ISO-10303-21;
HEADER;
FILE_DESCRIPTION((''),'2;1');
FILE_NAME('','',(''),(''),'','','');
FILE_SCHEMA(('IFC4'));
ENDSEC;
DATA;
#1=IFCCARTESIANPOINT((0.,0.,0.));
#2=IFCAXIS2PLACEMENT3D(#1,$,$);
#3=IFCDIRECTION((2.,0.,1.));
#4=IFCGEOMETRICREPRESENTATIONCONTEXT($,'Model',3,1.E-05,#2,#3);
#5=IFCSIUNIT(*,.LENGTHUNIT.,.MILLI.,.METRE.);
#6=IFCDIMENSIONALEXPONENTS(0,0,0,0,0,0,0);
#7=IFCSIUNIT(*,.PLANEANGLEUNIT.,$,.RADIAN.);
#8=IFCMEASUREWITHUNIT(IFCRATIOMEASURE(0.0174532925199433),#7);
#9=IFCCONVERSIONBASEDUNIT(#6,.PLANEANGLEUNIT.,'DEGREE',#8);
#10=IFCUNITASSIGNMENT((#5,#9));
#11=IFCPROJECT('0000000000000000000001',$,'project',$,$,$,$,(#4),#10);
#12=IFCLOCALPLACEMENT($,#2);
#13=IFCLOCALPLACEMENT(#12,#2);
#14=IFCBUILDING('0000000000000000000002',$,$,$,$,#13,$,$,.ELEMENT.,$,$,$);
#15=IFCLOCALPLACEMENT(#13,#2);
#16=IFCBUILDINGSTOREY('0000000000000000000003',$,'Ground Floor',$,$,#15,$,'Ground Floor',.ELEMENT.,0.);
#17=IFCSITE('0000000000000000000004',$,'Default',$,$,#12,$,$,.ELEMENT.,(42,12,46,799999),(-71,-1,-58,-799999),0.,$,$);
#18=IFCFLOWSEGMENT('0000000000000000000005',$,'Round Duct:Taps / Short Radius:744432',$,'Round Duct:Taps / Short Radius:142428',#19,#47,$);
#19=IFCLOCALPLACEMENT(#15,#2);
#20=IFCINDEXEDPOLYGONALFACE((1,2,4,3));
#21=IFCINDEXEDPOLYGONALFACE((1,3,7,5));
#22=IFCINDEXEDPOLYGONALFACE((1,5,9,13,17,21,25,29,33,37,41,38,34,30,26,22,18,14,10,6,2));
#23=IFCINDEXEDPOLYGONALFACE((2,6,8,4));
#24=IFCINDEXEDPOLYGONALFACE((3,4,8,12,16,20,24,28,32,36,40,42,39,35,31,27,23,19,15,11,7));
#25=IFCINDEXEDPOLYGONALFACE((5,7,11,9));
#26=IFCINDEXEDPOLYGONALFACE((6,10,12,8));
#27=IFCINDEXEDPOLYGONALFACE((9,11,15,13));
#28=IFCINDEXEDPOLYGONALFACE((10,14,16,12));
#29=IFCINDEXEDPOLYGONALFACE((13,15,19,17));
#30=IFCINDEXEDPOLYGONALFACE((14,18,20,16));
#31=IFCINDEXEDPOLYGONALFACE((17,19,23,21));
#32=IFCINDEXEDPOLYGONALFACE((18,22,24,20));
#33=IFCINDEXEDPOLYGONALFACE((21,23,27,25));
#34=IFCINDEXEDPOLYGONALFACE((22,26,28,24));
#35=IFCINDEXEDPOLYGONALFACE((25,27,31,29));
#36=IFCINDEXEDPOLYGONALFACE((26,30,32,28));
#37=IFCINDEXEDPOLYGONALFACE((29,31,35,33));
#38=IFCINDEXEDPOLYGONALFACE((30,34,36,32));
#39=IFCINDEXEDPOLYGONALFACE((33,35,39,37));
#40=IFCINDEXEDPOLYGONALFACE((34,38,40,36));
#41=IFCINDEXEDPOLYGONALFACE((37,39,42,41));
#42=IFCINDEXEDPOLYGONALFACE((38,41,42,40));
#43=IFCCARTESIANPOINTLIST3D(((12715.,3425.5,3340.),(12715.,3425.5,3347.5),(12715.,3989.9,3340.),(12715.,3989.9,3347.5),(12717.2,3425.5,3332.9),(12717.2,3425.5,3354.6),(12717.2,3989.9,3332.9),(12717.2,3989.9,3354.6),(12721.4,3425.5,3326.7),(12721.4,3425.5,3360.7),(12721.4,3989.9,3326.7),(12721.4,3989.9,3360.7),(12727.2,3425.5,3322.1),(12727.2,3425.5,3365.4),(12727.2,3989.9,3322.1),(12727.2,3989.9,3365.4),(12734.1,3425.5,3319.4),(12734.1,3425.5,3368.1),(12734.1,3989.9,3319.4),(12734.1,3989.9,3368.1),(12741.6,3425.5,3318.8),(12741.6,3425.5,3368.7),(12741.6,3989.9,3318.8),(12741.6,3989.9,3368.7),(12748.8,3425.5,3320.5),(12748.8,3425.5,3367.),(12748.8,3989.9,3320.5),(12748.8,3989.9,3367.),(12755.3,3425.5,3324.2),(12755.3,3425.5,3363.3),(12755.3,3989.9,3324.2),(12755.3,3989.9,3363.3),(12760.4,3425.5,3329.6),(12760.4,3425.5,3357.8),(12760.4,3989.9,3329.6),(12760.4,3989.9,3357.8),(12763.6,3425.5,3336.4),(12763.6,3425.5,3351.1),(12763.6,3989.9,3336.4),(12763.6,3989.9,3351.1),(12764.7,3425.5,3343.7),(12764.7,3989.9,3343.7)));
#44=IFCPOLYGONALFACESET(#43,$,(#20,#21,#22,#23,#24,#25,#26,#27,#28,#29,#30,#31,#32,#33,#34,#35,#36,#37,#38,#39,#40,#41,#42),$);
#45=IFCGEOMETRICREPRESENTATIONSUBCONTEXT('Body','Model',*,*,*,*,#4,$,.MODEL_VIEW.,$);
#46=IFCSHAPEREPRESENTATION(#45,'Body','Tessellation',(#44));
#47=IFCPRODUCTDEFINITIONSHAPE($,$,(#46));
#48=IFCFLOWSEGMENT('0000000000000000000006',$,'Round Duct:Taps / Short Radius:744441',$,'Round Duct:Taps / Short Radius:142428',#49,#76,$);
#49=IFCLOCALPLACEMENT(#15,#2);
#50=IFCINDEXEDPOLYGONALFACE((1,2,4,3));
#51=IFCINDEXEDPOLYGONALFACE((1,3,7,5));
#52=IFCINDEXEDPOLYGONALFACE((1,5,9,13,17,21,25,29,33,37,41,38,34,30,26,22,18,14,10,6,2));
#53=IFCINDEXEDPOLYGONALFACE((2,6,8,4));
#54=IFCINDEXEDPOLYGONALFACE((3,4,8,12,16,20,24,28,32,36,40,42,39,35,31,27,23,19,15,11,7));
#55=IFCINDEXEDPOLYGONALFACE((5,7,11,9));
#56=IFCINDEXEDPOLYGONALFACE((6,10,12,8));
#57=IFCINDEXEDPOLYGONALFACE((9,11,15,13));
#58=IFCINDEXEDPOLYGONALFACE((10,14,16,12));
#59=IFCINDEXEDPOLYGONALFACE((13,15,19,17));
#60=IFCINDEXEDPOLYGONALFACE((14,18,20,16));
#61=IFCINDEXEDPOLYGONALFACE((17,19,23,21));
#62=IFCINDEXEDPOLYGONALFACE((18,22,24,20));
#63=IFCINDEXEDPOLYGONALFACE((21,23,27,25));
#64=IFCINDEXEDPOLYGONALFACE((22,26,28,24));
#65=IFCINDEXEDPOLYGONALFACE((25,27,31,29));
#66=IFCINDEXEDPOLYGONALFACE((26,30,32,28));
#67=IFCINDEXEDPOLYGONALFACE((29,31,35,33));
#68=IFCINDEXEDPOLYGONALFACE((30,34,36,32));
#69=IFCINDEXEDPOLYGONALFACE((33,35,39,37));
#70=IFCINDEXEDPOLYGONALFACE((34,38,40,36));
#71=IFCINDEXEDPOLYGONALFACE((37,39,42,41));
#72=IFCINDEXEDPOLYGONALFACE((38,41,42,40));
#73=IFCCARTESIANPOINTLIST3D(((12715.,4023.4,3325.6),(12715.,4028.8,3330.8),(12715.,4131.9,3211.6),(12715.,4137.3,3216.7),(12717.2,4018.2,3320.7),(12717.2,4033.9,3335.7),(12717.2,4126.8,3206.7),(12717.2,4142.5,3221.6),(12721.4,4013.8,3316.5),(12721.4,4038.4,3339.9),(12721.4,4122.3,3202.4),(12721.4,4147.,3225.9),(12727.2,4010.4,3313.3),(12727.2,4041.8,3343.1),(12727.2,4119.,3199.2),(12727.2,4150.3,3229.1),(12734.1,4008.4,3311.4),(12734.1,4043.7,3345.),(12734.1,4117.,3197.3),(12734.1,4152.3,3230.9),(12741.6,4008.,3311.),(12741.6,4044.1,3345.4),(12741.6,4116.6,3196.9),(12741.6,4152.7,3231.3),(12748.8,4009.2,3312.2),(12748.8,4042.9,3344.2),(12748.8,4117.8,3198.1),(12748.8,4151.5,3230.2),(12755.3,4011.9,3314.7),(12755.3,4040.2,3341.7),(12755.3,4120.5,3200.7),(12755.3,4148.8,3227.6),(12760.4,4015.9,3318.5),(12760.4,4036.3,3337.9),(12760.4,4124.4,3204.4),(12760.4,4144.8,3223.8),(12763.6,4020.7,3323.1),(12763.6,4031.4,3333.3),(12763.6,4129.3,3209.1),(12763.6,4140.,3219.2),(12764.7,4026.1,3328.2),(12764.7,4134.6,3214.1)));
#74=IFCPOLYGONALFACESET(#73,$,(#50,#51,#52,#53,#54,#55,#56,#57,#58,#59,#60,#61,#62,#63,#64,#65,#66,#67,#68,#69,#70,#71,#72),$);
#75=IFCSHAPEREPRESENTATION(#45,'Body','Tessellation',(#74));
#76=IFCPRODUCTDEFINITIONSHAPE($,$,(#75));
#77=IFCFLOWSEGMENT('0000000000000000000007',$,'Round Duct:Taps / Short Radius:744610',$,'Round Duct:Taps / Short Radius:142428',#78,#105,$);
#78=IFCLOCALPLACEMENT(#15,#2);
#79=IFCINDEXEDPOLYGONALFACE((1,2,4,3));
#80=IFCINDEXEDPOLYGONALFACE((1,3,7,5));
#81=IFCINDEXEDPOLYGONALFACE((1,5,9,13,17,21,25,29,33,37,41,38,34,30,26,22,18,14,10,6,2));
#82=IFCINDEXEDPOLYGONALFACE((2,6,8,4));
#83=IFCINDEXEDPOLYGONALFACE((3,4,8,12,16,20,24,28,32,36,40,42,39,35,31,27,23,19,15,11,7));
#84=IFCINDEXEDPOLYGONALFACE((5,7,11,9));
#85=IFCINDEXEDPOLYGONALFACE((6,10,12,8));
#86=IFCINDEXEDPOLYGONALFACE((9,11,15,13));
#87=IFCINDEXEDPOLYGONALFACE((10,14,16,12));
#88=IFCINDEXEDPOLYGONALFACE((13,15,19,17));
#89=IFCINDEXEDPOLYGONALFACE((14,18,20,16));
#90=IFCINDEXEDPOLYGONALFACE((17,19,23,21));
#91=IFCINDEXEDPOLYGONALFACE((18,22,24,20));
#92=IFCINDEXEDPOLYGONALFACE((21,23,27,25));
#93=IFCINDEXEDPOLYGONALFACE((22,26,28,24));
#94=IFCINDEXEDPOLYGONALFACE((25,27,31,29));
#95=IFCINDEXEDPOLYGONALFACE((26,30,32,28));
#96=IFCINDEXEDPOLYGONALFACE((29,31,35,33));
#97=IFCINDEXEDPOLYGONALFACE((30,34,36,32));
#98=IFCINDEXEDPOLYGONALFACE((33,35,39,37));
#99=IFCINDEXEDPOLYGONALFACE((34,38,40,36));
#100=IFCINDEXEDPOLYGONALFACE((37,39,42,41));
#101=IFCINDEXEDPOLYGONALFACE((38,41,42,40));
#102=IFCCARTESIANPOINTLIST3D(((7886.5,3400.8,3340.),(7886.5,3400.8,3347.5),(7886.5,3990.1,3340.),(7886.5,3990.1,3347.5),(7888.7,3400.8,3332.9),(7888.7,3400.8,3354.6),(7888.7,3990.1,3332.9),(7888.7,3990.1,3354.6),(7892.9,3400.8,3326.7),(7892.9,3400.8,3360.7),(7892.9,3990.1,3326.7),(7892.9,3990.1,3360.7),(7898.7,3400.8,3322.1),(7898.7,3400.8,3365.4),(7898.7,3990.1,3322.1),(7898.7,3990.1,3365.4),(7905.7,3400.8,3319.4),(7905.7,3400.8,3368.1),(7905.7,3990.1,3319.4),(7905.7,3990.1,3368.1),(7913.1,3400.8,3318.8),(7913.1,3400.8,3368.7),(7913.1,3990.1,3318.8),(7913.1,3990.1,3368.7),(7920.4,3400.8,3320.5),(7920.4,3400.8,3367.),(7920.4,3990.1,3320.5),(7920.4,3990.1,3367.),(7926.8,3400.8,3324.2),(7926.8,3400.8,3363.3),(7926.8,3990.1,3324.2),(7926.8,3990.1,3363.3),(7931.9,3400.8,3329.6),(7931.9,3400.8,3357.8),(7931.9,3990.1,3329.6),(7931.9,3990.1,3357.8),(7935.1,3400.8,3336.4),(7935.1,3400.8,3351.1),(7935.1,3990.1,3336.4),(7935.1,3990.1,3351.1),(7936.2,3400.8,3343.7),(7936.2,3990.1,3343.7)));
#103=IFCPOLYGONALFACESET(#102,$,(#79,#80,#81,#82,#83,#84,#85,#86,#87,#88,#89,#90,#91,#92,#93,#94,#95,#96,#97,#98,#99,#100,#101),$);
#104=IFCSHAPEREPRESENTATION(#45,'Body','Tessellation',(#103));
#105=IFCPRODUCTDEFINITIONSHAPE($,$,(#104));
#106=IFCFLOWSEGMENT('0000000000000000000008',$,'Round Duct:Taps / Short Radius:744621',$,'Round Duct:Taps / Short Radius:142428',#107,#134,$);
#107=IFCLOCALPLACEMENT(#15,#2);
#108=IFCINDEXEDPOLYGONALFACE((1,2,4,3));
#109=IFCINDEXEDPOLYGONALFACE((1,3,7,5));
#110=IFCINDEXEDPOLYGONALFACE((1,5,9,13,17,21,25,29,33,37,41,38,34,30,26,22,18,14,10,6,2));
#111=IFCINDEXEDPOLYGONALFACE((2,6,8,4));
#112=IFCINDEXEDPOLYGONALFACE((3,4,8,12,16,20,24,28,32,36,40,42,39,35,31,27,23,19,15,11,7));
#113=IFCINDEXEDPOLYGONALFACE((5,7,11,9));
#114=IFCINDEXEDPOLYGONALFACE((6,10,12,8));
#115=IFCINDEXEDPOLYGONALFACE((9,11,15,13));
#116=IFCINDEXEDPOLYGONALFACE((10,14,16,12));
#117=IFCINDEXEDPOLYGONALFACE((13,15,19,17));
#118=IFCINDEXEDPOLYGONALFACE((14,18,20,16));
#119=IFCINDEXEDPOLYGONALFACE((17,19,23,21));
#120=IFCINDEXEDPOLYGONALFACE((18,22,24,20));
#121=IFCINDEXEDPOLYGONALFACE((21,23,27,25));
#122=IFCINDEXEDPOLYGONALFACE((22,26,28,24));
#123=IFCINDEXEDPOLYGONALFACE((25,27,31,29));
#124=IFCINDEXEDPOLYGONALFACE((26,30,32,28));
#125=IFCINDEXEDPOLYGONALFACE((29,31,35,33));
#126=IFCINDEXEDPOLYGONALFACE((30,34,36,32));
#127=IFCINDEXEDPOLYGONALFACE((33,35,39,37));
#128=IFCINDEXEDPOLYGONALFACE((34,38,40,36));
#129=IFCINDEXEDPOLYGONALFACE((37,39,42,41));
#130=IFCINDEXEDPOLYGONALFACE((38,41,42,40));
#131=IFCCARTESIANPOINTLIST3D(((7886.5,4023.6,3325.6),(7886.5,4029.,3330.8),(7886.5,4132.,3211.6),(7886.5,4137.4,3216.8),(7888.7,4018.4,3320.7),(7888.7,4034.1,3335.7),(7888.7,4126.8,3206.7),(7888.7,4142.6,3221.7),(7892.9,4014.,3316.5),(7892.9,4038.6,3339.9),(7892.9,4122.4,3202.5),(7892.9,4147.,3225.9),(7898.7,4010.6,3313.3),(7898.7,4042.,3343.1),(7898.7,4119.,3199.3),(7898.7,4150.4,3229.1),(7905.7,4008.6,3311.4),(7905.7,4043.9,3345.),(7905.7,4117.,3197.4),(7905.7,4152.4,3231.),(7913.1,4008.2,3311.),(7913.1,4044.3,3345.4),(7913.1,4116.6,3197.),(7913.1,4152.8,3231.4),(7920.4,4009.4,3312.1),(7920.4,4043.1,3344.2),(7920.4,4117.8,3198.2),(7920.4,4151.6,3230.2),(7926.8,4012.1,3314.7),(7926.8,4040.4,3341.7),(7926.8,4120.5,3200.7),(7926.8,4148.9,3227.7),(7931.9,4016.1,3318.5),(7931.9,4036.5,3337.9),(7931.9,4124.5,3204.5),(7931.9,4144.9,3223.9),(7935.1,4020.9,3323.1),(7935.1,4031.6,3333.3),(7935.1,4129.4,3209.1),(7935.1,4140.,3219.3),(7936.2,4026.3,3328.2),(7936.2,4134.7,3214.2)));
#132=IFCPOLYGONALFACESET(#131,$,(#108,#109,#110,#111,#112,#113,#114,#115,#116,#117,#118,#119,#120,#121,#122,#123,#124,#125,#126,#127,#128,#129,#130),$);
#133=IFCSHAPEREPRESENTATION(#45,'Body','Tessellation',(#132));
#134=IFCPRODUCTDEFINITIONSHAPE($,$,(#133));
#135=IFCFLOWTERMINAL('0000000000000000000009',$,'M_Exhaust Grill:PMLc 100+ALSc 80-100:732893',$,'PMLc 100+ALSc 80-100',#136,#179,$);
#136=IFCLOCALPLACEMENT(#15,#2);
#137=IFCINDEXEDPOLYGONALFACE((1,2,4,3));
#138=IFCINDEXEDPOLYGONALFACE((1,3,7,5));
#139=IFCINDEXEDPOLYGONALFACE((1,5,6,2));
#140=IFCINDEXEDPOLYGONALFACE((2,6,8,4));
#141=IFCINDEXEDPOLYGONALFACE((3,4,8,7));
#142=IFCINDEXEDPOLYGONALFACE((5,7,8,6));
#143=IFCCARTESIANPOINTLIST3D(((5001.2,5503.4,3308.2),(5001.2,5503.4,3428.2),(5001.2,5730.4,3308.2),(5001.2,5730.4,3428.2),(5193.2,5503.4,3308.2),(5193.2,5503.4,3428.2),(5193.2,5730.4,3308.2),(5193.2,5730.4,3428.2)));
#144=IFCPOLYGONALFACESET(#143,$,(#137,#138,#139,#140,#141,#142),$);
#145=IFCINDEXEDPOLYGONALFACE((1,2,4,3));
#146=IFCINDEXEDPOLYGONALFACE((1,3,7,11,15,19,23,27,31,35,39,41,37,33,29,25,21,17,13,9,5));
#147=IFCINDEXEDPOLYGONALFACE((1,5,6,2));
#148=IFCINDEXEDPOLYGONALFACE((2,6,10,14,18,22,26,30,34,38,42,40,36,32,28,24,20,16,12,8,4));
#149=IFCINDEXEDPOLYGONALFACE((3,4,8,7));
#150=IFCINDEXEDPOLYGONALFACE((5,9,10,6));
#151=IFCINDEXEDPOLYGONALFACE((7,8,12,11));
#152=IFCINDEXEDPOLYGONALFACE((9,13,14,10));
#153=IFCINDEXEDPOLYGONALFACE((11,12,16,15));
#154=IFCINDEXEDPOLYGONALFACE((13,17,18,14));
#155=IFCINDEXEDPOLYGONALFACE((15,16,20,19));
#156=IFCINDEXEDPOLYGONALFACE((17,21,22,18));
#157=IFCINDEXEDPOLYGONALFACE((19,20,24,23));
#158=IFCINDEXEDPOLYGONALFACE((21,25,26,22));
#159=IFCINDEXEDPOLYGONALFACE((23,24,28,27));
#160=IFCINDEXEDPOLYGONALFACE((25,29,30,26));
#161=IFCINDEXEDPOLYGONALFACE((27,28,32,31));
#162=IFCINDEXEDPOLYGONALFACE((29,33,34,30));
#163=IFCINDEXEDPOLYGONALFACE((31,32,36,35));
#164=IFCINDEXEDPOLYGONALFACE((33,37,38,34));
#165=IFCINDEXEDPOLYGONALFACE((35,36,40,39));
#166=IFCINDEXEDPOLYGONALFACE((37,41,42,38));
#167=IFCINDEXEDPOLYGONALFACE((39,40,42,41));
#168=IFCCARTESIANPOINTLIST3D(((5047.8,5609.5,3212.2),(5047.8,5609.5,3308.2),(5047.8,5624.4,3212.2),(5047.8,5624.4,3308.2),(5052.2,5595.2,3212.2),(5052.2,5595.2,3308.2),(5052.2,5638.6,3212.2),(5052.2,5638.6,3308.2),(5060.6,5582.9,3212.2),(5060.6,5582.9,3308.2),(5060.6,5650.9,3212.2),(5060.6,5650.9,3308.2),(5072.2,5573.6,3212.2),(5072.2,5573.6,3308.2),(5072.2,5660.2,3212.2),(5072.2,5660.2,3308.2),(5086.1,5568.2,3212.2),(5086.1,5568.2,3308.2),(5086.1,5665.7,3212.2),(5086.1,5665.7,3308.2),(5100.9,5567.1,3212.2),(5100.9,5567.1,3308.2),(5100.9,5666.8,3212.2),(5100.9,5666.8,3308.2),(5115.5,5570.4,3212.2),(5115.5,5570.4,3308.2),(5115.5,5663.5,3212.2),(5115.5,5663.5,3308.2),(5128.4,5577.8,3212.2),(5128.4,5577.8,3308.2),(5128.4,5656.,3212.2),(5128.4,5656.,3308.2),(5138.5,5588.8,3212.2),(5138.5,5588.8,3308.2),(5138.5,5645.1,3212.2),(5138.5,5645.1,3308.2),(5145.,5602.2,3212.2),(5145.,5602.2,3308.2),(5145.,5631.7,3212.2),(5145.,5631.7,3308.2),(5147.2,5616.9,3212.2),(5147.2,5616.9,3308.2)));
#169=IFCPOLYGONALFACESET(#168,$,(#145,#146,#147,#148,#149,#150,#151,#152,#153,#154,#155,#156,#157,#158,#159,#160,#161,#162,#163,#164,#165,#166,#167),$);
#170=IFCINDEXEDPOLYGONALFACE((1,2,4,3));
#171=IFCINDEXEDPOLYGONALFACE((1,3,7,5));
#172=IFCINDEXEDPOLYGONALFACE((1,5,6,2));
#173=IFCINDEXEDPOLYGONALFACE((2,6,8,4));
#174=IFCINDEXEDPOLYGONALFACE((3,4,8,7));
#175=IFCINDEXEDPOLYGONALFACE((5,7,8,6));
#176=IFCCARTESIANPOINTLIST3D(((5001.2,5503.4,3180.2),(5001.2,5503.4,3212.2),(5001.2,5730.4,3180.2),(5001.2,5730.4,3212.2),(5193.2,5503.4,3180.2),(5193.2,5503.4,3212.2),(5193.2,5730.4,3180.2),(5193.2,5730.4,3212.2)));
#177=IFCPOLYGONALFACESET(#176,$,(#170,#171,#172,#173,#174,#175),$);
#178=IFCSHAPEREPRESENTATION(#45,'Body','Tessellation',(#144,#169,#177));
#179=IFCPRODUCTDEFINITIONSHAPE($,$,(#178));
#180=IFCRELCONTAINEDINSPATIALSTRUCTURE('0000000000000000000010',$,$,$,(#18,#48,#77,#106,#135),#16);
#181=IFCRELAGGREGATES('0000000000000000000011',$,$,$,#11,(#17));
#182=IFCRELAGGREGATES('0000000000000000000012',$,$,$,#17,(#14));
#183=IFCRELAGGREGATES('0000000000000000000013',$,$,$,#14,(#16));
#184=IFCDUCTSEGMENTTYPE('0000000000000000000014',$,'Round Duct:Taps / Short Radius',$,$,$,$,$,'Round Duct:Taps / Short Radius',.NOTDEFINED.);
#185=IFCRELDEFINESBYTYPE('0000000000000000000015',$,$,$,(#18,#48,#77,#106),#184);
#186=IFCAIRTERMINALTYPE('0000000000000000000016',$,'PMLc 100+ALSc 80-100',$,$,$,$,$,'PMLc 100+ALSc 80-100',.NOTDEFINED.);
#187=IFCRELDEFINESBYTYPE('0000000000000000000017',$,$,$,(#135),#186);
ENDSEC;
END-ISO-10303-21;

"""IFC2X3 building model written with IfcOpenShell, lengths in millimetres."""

from ifc_helpers import new_model, entity, si_unit, converted_unit, direction, frame, frame_2d, origin, origin_2d_with_axis, place, context, subcontext, project, spatial, rectangle, circle, extrude, source, transform, mapped, type_object, type_shapes, element, save


model = new_model("IFC2X3")

# Units and contexts
model_context = context("Model", 3, precision=1e-05, world=origin(), true_north=direction((2.0, 0.0, 1.0)))
body_context = subcontext(model_context, "Body", "Model", "MODEL_VIEW")
ifc_project = project(units=[si_unit("LENGTHUNIT", "METRE", prefix="MILLI"), converted_unit("PLANEANGLEUNIT", "DEGREE", entity("IfcRatioMeasure", 0.0174532925199433), si_unit("PLANEANGLEUNIT", "RADIAN"), dimensions=[0, 0, 0, 0, 0, 0, 0])], contexts=[model_context])

# Site, building, storey
site_placement = place(None, origin())
site = spatial("IfcSite", under=ifc_project, at=site_placement, Name="Default", CompositionType="ELEMENT", RefLatitude=(42, 12, 46, 799999), RefLongitude=(-71, -1, -58, -799999), RefElevation=0.0)
building_placement = place(site_placement, origin())
building = spatial("IfcBuilding", under=site, at=building_placement, CompositionType="ELEMENT")
storey_placement = place(building_placement, origin())
storey = spatial("IfcBuildingStorey", under=building, at=storey_placement, Name="Ground Floor", LongName="Ground Floor", CompositionType="ELEMENT", Elevation=0.0)

# Flow segments
duct_segment_type = type_object("IfcDuctSegmentType", Name="Round Duct:Taps / Short Radius", ElementType="Round Duct:Taps / Short Radius", PredefinedType="NOTDEFINED")
flow_segment_1_placement = place(storey_placement, origin())
element("IfcFlowSegment", 1, at=flow_segment_1_placement, inside=storey, type_object=duct_segment_type, Name="Round Duct:Taps / Short Radius:744432", ObjectType="Round Duct:Taps / Short Radius:142428", context=body_context, shape_type="SweptSolid", body=[
    extrude(circle(Radius=25.0, at=origin_2d_with_axis()), frame((12739.7, 3425.5, 3343.7), z_axis=(0.0, 1.0, 0.0), x_axis=(1.0, 0.0, 0.0)), (0.0, 0.0, 1.0), 564.3),
])
flow_segment_2_placement = place(storey_placement, origin())
element("IfcFlowSegment", 2, at=flow_segment_2_placement, inside=storey, type_object=duct_segment_type, Name="Round Duct:Taps / Short Radius:744441", ObjectType="Round Duct:Taps / Short Radius:142428", context=body_context, shape_type="SweptSolid", body=[
    extrude(circle(Radius=25.0, at=frame_2d((0.0, 0.0), x_axis=(1.0, 0.0))), frame((12739.7, 4026.1, 3328.2), z_axis=(0.0, 0.689447, -0.724336), x_axis=(1.0, 0.0, 0.0)), (0.0, 0.0, 1.0), 157.5),
])
flow_segment_3_placement = place(storey_placement, origin())
element("IfcFlowSegment", 3, at=flow_segment_3_placement, inside=storey, type_object=duct_segment_type, Name="Round Duct:Taps / Short Radius:744610", ObjectType="Round Duct:Taps / Short Radius:142428", context=body_context, shape_type="SweptSolid", body=[
    extrude(circle(Radius=25.0, at=frame_2d((0.0, 0.0), x_axis=(1.0, 0.0))), frame((7911.2, 3400.8, 3343.7), z_axis=(0.0, 1.0, 0.0), x_axis=(1.0, 0.0, 0.0)), (0.0, 0.0, 1.0), 589.3),
])
flow_segment_4_placement = place(storey_placement, origin())
element("IfcFlowSegment", 4, at=flow_segment_4_placement, inside=storey, type_object=duct_segment_type, Name="Round Duct:Taps / Short Radius:744621", ObjectType="Round Duct:Taps / Short Radius:142428", context=body_context, shape_type="SweptSolid", body=[
    extrude(circle(Radius=25.0, at=frame_2d((0.0, 0.0), x_axis=(1.0, 0.0))), frame((7911.2, 4026.3, 3328.2), z_axis=(0.0, 0.689178, -0.724592), x_axis=(1.0, 0.0, 0.0)), (0.0, 0.0, 1.0), 157.3),
])

# Flow terminal
air_terminal_type_1 = type_object("IfcAirTerminalType", Name="PMLc 100+ALSc 80-100", ElementType="PMLc 100+ALSc 80-100", PredefinedType="NOTDEFINED")
shared_shape_1 = source(origin(), body_context, "Body", "SweptSolid", [
    extrude(rectangle(XDim=227.0, YDim=192.0, at=origin_2d_with_axis()), frame((0.0, 3.8, 128.0), z_axis=(0.0, 0.0, 1.0), x_axis=(0.0, 1.0, 0.0)), (0.0, 0.0, 1.0), 120.0),
    extrude(circle(Radius=50.0, at=frame_2d((0.0, 0.0), x_axis=(1.0, 0.0))), frame((0.0, 3.8, 32.0)), (0.0, 0.0, 1.0), 96.0),
    extrude(rectangle(XDim=227.0, YDim=192.0, at=origin_2d_with_axis()), frame((0.0, 3.8, 0.0), z_axis=(0.0, 0.0, 1.0), x_axis=(0.0, 1.0, 0.0)), (0.0, 0.0, 1.0), 32.0),
])
type_shapes(air_terminal_type_1, [shared_shape_1])
for number, where, name in (
    (5, (5097.2, 5613.2, 3180.2), "M_Exhaust Grill:PMLc 100+ALSc 80-100:732893"),
):
    element("IfcFlowTerminal", number, at=place(storey_placement, frame(where)), inside=storey, type_object=air_terminal_type_1, Name=name, ObjectType="PMLc 100+ALSc 80-100", context=body_context, shape_type="MappedRepresentation", body=[
        mapped(shared_shape_1, transform((0.0, 0.0, 0.0), scale=1.0)),
    ])

save(model, "model.ifc")
